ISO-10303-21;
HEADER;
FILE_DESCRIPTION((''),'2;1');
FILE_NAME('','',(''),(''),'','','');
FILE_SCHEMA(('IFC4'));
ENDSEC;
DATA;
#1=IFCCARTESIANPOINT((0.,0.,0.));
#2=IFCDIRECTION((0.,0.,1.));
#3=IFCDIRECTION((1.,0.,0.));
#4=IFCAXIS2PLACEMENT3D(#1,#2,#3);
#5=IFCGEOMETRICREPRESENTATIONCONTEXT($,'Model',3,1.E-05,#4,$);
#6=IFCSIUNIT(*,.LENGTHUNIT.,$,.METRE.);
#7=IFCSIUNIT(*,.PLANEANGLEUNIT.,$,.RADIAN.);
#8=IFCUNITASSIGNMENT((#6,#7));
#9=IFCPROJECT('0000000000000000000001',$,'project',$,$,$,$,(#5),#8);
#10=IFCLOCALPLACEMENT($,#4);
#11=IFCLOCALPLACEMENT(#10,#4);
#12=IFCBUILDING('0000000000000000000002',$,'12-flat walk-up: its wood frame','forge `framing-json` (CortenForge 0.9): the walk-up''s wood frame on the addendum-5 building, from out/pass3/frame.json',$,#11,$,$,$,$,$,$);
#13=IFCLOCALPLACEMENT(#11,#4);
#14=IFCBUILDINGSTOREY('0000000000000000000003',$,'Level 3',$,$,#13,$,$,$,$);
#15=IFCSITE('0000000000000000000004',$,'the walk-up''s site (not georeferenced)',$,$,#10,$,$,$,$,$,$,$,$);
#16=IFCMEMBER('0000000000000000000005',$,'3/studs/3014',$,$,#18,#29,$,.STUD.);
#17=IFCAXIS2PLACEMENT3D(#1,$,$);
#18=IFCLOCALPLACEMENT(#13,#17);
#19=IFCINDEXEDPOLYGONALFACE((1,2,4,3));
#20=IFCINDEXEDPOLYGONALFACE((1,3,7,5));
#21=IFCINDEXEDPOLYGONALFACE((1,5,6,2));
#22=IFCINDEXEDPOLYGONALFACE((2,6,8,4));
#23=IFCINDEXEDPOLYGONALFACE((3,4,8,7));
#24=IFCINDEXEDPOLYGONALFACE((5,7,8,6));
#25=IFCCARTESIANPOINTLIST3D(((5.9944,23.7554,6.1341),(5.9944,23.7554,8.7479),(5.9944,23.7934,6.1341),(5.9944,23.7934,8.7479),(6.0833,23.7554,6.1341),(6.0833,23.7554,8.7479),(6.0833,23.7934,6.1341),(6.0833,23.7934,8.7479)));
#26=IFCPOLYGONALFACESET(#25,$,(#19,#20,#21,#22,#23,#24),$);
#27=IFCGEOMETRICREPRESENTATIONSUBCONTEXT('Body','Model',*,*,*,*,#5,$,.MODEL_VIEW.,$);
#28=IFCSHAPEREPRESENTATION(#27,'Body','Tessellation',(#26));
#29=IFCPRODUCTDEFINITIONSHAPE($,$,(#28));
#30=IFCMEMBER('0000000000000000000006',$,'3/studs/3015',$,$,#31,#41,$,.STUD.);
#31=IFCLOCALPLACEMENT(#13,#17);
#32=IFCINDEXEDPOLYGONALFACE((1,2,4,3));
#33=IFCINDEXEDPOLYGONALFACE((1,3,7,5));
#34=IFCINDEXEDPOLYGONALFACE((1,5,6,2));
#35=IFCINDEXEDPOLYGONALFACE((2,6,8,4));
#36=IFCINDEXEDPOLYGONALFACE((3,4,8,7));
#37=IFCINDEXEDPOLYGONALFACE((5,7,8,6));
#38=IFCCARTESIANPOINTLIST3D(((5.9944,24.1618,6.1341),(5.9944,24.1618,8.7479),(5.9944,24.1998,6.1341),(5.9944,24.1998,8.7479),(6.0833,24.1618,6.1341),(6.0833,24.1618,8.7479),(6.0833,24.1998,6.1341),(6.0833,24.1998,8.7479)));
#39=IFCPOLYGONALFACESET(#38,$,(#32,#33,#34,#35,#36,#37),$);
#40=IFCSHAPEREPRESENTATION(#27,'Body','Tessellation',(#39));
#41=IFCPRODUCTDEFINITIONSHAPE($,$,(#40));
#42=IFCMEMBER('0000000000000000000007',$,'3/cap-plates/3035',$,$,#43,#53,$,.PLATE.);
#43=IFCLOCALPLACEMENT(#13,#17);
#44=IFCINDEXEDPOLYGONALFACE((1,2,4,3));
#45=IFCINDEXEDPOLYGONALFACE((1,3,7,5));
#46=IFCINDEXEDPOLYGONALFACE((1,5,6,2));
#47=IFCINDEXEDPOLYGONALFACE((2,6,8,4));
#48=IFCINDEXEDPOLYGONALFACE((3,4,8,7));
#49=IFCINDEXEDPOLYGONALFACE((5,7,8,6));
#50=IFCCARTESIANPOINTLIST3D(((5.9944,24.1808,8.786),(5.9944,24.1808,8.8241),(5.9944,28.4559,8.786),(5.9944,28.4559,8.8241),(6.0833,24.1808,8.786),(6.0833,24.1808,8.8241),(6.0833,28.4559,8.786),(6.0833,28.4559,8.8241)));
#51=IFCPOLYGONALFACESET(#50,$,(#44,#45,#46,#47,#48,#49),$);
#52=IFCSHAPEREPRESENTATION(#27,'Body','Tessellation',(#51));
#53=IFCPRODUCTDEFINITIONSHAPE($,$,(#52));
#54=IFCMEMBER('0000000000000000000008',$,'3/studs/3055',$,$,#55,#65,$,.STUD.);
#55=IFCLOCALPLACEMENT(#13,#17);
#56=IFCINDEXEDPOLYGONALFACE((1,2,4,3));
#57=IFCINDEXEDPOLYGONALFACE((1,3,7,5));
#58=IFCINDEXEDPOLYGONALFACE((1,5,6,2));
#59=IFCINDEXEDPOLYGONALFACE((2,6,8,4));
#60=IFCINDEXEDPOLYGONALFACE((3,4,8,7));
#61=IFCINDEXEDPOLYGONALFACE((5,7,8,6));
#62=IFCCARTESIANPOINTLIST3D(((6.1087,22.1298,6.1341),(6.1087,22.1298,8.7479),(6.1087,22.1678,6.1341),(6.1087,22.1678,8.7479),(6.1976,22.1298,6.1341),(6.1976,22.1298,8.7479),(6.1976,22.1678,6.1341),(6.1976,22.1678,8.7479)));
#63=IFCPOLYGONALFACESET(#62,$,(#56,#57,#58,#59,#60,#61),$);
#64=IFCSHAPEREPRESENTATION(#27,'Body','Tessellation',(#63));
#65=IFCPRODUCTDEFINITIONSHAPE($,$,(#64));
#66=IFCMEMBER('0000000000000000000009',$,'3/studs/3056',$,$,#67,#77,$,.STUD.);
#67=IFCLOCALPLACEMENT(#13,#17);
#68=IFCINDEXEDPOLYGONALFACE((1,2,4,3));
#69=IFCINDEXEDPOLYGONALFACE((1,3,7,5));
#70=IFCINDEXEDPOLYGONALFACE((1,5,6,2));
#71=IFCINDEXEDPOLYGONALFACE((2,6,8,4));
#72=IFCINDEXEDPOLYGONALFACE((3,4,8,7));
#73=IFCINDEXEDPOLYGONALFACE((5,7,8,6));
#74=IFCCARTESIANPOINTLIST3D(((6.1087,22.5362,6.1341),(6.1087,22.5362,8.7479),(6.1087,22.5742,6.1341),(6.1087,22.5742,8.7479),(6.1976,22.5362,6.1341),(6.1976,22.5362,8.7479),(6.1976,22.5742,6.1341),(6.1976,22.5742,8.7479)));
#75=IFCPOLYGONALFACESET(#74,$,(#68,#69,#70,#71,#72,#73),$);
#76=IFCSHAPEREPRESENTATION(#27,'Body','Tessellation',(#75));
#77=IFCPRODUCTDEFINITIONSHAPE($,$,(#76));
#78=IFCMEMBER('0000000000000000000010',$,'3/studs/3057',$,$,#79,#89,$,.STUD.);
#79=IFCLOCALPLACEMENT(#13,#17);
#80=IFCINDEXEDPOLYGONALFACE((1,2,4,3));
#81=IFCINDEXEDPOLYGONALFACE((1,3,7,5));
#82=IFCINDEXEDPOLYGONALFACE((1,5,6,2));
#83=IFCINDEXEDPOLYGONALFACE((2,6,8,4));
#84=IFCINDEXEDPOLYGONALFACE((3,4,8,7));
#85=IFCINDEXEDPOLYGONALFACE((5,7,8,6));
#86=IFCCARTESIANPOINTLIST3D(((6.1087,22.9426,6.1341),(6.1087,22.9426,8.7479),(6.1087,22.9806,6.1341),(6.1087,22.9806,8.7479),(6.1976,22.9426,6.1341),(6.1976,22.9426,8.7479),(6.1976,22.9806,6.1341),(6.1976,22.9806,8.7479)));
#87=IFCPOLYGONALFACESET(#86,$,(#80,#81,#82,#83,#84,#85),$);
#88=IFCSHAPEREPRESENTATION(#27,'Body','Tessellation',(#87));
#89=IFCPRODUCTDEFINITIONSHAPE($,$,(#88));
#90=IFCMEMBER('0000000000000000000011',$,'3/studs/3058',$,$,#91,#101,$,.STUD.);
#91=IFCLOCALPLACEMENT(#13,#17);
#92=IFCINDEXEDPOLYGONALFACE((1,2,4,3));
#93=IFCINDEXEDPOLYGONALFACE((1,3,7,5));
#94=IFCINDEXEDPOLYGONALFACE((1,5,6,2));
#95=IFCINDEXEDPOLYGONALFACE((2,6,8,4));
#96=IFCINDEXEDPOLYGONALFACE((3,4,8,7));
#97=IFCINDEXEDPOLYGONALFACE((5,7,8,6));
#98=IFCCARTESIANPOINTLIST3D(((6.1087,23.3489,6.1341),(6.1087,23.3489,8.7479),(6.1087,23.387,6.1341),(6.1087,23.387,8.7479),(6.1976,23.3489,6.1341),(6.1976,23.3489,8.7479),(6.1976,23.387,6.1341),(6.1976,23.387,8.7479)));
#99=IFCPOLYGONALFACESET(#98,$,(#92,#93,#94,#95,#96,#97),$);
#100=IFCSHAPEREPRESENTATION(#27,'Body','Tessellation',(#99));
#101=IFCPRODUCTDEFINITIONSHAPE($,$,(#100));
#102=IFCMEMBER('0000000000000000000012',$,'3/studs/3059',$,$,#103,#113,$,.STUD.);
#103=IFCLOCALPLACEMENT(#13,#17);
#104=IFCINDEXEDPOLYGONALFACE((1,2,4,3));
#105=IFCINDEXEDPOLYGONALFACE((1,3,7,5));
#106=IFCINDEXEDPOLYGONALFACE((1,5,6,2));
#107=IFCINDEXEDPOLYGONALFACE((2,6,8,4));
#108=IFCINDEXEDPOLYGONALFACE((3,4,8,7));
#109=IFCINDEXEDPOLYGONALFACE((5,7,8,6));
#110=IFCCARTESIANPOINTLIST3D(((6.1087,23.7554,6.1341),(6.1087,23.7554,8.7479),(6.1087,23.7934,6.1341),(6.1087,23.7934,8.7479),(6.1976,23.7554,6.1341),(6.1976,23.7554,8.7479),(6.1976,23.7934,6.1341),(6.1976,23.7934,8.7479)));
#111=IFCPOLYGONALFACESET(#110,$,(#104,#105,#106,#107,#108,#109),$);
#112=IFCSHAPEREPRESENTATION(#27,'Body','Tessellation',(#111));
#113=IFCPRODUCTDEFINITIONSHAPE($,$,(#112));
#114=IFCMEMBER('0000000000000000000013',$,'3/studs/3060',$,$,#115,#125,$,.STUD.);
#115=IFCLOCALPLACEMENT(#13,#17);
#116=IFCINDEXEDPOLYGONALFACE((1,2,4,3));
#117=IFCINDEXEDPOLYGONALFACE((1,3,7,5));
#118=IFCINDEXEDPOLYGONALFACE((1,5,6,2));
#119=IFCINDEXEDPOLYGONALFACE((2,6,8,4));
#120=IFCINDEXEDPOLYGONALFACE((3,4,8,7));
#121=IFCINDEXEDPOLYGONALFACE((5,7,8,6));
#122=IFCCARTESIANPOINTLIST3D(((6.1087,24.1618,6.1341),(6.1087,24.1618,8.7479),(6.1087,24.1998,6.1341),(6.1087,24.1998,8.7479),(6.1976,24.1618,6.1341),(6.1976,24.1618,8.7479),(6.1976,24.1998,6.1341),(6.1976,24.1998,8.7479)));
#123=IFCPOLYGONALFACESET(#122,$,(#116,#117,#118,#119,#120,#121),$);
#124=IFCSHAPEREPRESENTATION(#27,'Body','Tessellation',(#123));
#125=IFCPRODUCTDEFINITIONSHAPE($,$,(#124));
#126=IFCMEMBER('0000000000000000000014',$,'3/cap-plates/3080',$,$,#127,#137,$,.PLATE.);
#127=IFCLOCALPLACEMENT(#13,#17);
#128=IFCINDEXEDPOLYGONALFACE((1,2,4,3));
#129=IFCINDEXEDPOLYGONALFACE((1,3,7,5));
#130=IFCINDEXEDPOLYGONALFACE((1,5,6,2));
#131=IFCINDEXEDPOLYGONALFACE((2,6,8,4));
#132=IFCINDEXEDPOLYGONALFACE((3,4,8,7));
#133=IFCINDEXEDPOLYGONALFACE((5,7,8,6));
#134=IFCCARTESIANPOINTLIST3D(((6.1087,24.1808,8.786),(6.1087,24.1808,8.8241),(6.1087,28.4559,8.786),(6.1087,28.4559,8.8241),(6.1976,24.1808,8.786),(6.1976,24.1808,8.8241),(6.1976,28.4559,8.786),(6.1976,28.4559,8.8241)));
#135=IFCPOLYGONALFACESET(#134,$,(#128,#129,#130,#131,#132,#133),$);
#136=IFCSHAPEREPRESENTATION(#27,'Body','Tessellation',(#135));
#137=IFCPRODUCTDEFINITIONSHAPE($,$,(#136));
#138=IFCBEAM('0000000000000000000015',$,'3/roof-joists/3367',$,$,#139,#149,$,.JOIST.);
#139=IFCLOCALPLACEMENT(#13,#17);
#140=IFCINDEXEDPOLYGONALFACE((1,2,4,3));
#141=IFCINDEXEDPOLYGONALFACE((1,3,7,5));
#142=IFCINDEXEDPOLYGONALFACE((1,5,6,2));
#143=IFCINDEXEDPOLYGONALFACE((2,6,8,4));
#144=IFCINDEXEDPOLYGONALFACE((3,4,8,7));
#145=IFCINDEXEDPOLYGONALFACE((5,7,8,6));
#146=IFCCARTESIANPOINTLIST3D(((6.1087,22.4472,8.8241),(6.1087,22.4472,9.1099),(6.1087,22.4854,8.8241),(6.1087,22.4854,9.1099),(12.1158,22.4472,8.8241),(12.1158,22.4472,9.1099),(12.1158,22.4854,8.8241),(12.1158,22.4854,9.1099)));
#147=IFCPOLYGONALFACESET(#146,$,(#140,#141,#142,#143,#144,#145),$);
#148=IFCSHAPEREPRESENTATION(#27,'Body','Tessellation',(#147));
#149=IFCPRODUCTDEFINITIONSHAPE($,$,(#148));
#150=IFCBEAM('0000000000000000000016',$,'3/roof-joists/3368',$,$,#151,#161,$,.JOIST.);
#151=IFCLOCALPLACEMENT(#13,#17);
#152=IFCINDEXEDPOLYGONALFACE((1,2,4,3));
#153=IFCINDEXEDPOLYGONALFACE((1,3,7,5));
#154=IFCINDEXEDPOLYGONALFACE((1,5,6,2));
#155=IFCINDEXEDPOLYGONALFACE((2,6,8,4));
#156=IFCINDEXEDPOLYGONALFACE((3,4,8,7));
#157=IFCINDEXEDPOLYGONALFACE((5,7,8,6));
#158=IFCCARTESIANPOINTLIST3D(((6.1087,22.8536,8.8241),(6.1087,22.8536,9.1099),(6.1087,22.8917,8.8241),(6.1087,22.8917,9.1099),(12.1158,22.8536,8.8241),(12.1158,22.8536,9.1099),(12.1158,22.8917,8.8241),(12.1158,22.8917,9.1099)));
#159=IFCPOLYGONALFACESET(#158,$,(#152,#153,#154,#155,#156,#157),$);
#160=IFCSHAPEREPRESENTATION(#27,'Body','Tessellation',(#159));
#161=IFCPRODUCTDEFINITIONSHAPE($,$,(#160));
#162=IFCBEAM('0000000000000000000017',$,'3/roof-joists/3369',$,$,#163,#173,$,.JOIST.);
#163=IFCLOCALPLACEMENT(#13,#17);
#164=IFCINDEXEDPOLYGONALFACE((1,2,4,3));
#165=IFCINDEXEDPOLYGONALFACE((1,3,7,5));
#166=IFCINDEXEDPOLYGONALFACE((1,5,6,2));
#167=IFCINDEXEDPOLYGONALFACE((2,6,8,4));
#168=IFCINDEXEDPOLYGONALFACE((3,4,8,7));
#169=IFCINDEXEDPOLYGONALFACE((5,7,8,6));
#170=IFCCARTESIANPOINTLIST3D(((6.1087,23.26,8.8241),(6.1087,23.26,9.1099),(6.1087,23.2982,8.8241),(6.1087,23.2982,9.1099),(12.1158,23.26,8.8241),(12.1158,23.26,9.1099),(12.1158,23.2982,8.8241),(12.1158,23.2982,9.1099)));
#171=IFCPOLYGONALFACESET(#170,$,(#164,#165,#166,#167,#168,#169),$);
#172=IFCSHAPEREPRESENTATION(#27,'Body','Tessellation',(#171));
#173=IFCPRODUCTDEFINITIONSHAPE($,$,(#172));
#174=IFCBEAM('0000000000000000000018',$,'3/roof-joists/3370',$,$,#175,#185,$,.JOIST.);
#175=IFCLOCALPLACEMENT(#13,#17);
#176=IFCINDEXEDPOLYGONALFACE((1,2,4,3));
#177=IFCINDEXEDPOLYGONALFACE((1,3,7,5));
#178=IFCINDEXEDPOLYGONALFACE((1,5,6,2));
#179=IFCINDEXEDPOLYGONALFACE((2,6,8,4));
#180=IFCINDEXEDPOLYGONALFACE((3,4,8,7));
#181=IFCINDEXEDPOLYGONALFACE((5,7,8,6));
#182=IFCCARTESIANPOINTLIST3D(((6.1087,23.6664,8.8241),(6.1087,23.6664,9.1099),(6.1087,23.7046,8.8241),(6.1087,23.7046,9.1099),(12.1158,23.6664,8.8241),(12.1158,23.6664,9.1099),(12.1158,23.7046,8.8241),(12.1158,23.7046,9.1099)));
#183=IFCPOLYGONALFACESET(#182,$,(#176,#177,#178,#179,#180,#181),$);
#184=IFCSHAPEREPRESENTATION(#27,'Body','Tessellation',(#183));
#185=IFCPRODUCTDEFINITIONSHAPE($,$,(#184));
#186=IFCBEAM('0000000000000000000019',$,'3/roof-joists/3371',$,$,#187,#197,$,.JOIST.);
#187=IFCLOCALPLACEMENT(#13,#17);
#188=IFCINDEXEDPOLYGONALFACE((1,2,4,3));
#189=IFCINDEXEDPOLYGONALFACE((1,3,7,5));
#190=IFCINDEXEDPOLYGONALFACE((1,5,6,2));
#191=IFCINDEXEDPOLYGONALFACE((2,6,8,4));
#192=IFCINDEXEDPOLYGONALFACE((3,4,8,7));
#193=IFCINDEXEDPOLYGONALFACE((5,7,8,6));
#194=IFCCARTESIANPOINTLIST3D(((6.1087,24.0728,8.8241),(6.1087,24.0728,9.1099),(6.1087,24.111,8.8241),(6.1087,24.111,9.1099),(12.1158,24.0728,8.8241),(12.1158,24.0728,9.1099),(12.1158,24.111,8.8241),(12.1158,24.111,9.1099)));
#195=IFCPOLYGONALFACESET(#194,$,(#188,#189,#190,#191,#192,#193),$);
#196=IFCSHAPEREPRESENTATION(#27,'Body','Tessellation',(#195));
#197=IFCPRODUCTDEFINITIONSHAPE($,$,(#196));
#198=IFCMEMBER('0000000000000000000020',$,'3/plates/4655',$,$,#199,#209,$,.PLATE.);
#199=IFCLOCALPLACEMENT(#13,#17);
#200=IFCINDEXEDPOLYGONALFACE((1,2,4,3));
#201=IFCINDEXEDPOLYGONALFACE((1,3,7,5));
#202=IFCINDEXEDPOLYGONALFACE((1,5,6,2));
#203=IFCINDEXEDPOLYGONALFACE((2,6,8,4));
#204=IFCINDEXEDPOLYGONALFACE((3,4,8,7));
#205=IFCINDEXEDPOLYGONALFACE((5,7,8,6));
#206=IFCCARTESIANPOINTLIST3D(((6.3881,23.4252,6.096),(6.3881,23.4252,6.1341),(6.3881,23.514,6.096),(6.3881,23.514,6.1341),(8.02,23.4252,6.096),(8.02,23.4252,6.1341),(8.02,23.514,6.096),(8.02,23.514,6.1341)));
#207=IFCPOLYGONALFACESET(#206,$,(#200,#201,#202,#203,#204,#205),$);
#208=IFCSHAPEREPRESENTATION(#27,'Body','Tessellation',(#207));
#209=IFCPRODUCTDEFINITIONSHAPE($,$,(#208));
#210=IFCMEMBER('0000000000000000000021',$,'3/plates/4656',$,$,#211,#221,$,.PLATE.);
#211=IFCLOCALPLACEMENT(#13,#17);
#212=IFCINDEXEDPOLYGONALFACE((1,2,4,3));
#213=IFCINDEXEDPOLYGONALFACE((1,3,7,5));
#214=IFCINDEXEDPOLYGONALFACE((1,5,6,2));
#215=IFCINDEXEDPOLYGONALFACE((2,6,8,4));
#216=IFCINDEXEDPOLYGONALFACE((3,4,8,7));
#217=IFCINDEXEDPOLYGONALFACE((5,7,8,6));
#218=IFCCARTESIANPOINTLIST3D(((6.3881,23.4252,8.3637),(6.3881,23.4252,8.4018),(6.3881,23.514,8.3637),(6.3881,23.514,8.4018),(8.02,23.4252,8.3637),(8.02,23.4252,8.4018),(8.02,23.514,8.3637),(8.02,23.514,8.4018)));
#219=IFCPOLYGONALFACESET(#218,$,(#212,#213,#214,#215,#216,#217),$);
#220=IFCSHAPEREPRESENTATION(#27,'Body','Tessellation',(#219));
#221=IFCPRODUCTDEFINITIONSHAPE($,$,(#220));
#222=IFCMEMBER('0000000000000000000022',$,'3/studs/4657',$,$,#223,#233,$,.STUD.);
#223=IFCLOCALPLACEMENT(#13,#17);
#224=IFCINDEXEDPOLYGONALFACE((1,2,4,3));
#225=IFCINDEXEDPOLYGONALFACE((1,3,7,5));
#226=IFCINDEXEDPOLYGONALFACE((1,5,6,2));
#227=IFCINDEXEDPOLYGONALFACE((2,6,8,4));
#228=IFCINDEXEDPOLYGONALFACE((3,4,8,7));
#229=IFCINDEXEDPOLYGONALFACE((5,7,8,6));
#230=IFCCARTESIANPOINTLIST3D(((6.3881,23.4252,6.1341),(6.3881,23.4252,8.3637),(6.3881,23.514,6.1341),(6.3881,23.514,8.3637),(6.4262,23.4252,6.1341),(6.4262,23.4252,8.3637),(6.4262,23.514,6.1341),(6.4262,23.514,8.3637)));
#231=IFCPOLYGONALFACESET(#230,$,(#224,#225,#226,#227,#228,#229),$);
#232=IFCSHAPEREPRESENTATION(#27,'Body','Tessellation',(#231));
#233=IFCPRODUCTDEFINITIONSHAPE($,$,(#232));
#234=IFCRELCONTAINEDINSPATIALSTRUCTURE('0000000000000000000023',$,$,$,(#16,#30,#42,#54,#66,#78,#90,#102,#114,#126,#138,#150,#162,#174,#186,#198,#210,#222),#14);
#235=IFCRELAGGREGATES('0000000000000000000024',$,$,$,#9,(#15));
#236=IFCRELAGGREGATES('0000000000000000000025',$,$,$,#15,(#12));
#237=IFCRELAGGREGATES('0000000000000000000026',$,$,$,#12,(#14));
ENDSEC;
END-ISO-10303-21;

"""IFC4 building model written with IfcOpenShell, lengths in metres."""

from ifc_helpers import new_model, si_unit, frame, frame_2d, origin, origin_with_axes, place, context, subcontext, project, spatial, rectangle, extrude, element, save


model = new_model("IFC4")

# Units and contexts
model_context = context("Model", 3, precision=1e-05, world=origin_with_axes())
body_context = subcontext(model_context, "Body", "Model", "MODEL_VIEW")
ifc_project = project(units=[si_unit("LENGTHUNIT", "METRE"), si_unit("PLANEANGLEUNIT", "RADIAN")], contexts=[model_context])

# Site, building, storey
site_placement = place(None, origin_with_axes())
site = spatial("IfcSite", under=ifc_project, at=site_placement, Name="the walk-up's site (not georeferenced)")
building_placement = place(site_placement, origin_with_axes())
building = spatial("IfcBuilding", under=site, at=building_placement, Name="12-flat walk-up: its wood frame", Description="forge `framing-json` (CortenForge 0.9): the walk-up's wood frame on the addendum-5 building, from out/pass3/frame.json")
storey_placement = place(building_placement, origin_with_axes())
storey = spatial("IfcBuildingStorey", under=building, at=storey_placement, Name="Level 3")

# Members
for number, where, z_axis, x_axis, name in (
    (1, (5.9944, 23.7553, 6.1341), (0.0, 0.0, 1.0), (1.0, 0.0, 0.0), "3/studs/3014"),
    (2, (5.9944, 24.1618, 6.1341), (0.0, 0.0, 1.0), (1.0, 0.0, 0.0), "3/studs/3015"),
):
    element("IfcMember", number, at=place(storey_placement, frame(where, z_axis=z_axis, x_axis=x_axis)), inside=storey, Name=name, PredefinedType="STUD", context=body_context, shape_type="SweptSolid", body=[
        extrude(rectangle(XDim=0.0889, YDim=0.0381, at=frame_2d((0.0445, 0.0191))), origin(), (0.0, 0.0, 1.0), 2.6138),
    ])
member_1_placement = place(storey_placement, frame((5.9944, 24.1808, 8.786), z_axis=(0.0, 0.0, 1.0), x_axis=(1.0, 0.0, 0.0)))
element("IfcMember", 3, at=member_1_placement, inside=storey, Name="3/cap-plates/3035", PredefinedType="PLATE", context=body_context, shape_type="SweptSolid", body=[
    extrude(rectangle(XDim=0.0889, YDim=4.2751, at=frame_2d((0.0445, 2.1376))), origin(), (0.0, 0.0, 1.0), 0.0381),
])
for number, where, z_axis, x_axis, name in (
    (4, (6.1087, 22.1298, 6.1341), (0.0, 0.0, 1.0), (1.0, 0.0, 0.0), "3/studs/3055"),
    (5, (6.1087, 22.5361, 6.1341), (0.0, 0.0, 1.0), (1.0, 0.0, 0.0), "3/studs/3056"),
    (6, (6.1087, 22.9426, 6.1341), (0.0, 0.0, 1.0), (1.0, 0.0, 0.0), "3/studs/3057"),
    (7, (6.1087, 23.3489, 6.1341), (0.0, 0.0, 1.0), (1.0, 0.0, 0.0), "3/studs/3058"),
    (8, (6.1087, 23.7553, 6.1341), (0.0, 0.0, 1.0), (1.0, 0.0, 0.0), "3/studs/3059"),
    (9, (6.1087, 24.1618, 6.1341), (0.0, 0.0, 1.0), (1.0, 0.0, 0.0), "3/studs/3060"),
):
    element("IfcMember", number, at=place(storey_placement, frame(where, z_axis=z_axis, x_axis=x_axis)), inside=storey, Name=name, PredefinedType="STUD", context=body_context, shape_type="SweptSolid", body=[
        extrude(rectangle(XDim=0.0889, YDim=0.0381, at=frame_2d((0.0445, 0.0191))), origin(), (0.0, 0.0, 1.0), 2.6138),
    ])
member_2_placement = place(storey_placement, frame((6.1087, 24.1808, 8.786), z_axis=(0.0, 0.0, 1.0), x_axis=(1.0, 0.0, 0.0)))
element("IfcMember", 10, at=member_2_placement, inside=storey, Name="3/cap-plates/3080", PredefinedType="PLATE", context=body_context, shape_type="SweptSolid", body=[
    extrude(rectangle(XDim=0.0889, YDim=4.2751, at=frame_2d((0.0445, 2.1376))), origin(), (0.0, 0.0, 1.0), 0.0381),
])

# Beams
for number, where, z_axis, x_axis, name in (
    (11, (6.1087, 22.4473, 8.8241), (0.0, 0.0, 1.0), (1.0, 0.0, 0.0), "3/roof-joists/3367"),
    (12, (6.1087, 22.8536, 8.8241), (0.0, 0.0, 1.0), (1.0, 0.0, 0.0), "3/roof-joists/3368"),
    (13, (6.1087, 23.26, 8.8241), (0.0, 0.0, 1.0), (1.0, 0.0, 0.0), "3/roof-joists/3369"),
    (14, (6.1087, 23.6665, 8.8241), (0.0, 0.0, 1.0), (1.0, 0.0, 0.0), "3/roof-joists/3370"),
    (15, (6.1087, 24.0728, 8.8241), (0.0, 0.0, 1.0), (1.0, 0.0, 0.0), "3/roof-joists/3371"),
):
    element("IfcBeam", number, at=place(storey_placement, frame(where, z_axis=z_axis, x_axis=x_axis)), inside=storey, Name=name, PredefinedType="JOIST", context=body_context, shape_type="SweptSolid", body=[
        extrude(rectangle(XDim=6.0071, YDim=0.0381, at=frame_2d((3.0036, 0.0191))), origin(), (0.0, 0.0, 1.0), 0.2858),
    ])

# Members
for number, where, z_axis, x_axis, name in (
    (16, (6.3881, 23.4251, 6.096), (0.0, 0.0, 1.0), (1.0, 0.0, 0.0), "3/plates/4655"),
    (17, (6.3881, 23.4251, 8.3637), (0.0, 0.0, 1.0), (1.0, 0.0, 0.0), "3/plates/4656"),
):
    element("IfcMember", number, at=place(storey_placement, frame(where, z_axis=z_axis, x_axis=x_axis)), inside=storey, Name=name, PredefinedType="PLATE", context=body_context, shape_type="SweptSolid", body=[
        extrude(rectangle(XDim=1.6319, YDim=0.0889, at=frame_2d((0.816, 0.0445))), origin(), (0.0, 0.0, 1.0), 0.0381),
    ])
member_3_placement = place(storey_placement, frame((6.3881, 23.4251, 6.1341), z_axis=(0.0, 0.0, 1.0), x_axis=(1.0, 0.0, 0.0)))
element("IfcMember", 18, at=member_3_placement, inside=storey, Name="3/studs/4657", PredefinedType="STUD", context=body_context, shape_type="SweptSolid", body=[
    extrude(rectangle(XDim=0.0381, YDim=0.0889, at=frame_2d((0.0191, 0.0445))), origin(), (0.0, 0.0, 1.0), 2.2296),
])

save(model, "model.ifc")
